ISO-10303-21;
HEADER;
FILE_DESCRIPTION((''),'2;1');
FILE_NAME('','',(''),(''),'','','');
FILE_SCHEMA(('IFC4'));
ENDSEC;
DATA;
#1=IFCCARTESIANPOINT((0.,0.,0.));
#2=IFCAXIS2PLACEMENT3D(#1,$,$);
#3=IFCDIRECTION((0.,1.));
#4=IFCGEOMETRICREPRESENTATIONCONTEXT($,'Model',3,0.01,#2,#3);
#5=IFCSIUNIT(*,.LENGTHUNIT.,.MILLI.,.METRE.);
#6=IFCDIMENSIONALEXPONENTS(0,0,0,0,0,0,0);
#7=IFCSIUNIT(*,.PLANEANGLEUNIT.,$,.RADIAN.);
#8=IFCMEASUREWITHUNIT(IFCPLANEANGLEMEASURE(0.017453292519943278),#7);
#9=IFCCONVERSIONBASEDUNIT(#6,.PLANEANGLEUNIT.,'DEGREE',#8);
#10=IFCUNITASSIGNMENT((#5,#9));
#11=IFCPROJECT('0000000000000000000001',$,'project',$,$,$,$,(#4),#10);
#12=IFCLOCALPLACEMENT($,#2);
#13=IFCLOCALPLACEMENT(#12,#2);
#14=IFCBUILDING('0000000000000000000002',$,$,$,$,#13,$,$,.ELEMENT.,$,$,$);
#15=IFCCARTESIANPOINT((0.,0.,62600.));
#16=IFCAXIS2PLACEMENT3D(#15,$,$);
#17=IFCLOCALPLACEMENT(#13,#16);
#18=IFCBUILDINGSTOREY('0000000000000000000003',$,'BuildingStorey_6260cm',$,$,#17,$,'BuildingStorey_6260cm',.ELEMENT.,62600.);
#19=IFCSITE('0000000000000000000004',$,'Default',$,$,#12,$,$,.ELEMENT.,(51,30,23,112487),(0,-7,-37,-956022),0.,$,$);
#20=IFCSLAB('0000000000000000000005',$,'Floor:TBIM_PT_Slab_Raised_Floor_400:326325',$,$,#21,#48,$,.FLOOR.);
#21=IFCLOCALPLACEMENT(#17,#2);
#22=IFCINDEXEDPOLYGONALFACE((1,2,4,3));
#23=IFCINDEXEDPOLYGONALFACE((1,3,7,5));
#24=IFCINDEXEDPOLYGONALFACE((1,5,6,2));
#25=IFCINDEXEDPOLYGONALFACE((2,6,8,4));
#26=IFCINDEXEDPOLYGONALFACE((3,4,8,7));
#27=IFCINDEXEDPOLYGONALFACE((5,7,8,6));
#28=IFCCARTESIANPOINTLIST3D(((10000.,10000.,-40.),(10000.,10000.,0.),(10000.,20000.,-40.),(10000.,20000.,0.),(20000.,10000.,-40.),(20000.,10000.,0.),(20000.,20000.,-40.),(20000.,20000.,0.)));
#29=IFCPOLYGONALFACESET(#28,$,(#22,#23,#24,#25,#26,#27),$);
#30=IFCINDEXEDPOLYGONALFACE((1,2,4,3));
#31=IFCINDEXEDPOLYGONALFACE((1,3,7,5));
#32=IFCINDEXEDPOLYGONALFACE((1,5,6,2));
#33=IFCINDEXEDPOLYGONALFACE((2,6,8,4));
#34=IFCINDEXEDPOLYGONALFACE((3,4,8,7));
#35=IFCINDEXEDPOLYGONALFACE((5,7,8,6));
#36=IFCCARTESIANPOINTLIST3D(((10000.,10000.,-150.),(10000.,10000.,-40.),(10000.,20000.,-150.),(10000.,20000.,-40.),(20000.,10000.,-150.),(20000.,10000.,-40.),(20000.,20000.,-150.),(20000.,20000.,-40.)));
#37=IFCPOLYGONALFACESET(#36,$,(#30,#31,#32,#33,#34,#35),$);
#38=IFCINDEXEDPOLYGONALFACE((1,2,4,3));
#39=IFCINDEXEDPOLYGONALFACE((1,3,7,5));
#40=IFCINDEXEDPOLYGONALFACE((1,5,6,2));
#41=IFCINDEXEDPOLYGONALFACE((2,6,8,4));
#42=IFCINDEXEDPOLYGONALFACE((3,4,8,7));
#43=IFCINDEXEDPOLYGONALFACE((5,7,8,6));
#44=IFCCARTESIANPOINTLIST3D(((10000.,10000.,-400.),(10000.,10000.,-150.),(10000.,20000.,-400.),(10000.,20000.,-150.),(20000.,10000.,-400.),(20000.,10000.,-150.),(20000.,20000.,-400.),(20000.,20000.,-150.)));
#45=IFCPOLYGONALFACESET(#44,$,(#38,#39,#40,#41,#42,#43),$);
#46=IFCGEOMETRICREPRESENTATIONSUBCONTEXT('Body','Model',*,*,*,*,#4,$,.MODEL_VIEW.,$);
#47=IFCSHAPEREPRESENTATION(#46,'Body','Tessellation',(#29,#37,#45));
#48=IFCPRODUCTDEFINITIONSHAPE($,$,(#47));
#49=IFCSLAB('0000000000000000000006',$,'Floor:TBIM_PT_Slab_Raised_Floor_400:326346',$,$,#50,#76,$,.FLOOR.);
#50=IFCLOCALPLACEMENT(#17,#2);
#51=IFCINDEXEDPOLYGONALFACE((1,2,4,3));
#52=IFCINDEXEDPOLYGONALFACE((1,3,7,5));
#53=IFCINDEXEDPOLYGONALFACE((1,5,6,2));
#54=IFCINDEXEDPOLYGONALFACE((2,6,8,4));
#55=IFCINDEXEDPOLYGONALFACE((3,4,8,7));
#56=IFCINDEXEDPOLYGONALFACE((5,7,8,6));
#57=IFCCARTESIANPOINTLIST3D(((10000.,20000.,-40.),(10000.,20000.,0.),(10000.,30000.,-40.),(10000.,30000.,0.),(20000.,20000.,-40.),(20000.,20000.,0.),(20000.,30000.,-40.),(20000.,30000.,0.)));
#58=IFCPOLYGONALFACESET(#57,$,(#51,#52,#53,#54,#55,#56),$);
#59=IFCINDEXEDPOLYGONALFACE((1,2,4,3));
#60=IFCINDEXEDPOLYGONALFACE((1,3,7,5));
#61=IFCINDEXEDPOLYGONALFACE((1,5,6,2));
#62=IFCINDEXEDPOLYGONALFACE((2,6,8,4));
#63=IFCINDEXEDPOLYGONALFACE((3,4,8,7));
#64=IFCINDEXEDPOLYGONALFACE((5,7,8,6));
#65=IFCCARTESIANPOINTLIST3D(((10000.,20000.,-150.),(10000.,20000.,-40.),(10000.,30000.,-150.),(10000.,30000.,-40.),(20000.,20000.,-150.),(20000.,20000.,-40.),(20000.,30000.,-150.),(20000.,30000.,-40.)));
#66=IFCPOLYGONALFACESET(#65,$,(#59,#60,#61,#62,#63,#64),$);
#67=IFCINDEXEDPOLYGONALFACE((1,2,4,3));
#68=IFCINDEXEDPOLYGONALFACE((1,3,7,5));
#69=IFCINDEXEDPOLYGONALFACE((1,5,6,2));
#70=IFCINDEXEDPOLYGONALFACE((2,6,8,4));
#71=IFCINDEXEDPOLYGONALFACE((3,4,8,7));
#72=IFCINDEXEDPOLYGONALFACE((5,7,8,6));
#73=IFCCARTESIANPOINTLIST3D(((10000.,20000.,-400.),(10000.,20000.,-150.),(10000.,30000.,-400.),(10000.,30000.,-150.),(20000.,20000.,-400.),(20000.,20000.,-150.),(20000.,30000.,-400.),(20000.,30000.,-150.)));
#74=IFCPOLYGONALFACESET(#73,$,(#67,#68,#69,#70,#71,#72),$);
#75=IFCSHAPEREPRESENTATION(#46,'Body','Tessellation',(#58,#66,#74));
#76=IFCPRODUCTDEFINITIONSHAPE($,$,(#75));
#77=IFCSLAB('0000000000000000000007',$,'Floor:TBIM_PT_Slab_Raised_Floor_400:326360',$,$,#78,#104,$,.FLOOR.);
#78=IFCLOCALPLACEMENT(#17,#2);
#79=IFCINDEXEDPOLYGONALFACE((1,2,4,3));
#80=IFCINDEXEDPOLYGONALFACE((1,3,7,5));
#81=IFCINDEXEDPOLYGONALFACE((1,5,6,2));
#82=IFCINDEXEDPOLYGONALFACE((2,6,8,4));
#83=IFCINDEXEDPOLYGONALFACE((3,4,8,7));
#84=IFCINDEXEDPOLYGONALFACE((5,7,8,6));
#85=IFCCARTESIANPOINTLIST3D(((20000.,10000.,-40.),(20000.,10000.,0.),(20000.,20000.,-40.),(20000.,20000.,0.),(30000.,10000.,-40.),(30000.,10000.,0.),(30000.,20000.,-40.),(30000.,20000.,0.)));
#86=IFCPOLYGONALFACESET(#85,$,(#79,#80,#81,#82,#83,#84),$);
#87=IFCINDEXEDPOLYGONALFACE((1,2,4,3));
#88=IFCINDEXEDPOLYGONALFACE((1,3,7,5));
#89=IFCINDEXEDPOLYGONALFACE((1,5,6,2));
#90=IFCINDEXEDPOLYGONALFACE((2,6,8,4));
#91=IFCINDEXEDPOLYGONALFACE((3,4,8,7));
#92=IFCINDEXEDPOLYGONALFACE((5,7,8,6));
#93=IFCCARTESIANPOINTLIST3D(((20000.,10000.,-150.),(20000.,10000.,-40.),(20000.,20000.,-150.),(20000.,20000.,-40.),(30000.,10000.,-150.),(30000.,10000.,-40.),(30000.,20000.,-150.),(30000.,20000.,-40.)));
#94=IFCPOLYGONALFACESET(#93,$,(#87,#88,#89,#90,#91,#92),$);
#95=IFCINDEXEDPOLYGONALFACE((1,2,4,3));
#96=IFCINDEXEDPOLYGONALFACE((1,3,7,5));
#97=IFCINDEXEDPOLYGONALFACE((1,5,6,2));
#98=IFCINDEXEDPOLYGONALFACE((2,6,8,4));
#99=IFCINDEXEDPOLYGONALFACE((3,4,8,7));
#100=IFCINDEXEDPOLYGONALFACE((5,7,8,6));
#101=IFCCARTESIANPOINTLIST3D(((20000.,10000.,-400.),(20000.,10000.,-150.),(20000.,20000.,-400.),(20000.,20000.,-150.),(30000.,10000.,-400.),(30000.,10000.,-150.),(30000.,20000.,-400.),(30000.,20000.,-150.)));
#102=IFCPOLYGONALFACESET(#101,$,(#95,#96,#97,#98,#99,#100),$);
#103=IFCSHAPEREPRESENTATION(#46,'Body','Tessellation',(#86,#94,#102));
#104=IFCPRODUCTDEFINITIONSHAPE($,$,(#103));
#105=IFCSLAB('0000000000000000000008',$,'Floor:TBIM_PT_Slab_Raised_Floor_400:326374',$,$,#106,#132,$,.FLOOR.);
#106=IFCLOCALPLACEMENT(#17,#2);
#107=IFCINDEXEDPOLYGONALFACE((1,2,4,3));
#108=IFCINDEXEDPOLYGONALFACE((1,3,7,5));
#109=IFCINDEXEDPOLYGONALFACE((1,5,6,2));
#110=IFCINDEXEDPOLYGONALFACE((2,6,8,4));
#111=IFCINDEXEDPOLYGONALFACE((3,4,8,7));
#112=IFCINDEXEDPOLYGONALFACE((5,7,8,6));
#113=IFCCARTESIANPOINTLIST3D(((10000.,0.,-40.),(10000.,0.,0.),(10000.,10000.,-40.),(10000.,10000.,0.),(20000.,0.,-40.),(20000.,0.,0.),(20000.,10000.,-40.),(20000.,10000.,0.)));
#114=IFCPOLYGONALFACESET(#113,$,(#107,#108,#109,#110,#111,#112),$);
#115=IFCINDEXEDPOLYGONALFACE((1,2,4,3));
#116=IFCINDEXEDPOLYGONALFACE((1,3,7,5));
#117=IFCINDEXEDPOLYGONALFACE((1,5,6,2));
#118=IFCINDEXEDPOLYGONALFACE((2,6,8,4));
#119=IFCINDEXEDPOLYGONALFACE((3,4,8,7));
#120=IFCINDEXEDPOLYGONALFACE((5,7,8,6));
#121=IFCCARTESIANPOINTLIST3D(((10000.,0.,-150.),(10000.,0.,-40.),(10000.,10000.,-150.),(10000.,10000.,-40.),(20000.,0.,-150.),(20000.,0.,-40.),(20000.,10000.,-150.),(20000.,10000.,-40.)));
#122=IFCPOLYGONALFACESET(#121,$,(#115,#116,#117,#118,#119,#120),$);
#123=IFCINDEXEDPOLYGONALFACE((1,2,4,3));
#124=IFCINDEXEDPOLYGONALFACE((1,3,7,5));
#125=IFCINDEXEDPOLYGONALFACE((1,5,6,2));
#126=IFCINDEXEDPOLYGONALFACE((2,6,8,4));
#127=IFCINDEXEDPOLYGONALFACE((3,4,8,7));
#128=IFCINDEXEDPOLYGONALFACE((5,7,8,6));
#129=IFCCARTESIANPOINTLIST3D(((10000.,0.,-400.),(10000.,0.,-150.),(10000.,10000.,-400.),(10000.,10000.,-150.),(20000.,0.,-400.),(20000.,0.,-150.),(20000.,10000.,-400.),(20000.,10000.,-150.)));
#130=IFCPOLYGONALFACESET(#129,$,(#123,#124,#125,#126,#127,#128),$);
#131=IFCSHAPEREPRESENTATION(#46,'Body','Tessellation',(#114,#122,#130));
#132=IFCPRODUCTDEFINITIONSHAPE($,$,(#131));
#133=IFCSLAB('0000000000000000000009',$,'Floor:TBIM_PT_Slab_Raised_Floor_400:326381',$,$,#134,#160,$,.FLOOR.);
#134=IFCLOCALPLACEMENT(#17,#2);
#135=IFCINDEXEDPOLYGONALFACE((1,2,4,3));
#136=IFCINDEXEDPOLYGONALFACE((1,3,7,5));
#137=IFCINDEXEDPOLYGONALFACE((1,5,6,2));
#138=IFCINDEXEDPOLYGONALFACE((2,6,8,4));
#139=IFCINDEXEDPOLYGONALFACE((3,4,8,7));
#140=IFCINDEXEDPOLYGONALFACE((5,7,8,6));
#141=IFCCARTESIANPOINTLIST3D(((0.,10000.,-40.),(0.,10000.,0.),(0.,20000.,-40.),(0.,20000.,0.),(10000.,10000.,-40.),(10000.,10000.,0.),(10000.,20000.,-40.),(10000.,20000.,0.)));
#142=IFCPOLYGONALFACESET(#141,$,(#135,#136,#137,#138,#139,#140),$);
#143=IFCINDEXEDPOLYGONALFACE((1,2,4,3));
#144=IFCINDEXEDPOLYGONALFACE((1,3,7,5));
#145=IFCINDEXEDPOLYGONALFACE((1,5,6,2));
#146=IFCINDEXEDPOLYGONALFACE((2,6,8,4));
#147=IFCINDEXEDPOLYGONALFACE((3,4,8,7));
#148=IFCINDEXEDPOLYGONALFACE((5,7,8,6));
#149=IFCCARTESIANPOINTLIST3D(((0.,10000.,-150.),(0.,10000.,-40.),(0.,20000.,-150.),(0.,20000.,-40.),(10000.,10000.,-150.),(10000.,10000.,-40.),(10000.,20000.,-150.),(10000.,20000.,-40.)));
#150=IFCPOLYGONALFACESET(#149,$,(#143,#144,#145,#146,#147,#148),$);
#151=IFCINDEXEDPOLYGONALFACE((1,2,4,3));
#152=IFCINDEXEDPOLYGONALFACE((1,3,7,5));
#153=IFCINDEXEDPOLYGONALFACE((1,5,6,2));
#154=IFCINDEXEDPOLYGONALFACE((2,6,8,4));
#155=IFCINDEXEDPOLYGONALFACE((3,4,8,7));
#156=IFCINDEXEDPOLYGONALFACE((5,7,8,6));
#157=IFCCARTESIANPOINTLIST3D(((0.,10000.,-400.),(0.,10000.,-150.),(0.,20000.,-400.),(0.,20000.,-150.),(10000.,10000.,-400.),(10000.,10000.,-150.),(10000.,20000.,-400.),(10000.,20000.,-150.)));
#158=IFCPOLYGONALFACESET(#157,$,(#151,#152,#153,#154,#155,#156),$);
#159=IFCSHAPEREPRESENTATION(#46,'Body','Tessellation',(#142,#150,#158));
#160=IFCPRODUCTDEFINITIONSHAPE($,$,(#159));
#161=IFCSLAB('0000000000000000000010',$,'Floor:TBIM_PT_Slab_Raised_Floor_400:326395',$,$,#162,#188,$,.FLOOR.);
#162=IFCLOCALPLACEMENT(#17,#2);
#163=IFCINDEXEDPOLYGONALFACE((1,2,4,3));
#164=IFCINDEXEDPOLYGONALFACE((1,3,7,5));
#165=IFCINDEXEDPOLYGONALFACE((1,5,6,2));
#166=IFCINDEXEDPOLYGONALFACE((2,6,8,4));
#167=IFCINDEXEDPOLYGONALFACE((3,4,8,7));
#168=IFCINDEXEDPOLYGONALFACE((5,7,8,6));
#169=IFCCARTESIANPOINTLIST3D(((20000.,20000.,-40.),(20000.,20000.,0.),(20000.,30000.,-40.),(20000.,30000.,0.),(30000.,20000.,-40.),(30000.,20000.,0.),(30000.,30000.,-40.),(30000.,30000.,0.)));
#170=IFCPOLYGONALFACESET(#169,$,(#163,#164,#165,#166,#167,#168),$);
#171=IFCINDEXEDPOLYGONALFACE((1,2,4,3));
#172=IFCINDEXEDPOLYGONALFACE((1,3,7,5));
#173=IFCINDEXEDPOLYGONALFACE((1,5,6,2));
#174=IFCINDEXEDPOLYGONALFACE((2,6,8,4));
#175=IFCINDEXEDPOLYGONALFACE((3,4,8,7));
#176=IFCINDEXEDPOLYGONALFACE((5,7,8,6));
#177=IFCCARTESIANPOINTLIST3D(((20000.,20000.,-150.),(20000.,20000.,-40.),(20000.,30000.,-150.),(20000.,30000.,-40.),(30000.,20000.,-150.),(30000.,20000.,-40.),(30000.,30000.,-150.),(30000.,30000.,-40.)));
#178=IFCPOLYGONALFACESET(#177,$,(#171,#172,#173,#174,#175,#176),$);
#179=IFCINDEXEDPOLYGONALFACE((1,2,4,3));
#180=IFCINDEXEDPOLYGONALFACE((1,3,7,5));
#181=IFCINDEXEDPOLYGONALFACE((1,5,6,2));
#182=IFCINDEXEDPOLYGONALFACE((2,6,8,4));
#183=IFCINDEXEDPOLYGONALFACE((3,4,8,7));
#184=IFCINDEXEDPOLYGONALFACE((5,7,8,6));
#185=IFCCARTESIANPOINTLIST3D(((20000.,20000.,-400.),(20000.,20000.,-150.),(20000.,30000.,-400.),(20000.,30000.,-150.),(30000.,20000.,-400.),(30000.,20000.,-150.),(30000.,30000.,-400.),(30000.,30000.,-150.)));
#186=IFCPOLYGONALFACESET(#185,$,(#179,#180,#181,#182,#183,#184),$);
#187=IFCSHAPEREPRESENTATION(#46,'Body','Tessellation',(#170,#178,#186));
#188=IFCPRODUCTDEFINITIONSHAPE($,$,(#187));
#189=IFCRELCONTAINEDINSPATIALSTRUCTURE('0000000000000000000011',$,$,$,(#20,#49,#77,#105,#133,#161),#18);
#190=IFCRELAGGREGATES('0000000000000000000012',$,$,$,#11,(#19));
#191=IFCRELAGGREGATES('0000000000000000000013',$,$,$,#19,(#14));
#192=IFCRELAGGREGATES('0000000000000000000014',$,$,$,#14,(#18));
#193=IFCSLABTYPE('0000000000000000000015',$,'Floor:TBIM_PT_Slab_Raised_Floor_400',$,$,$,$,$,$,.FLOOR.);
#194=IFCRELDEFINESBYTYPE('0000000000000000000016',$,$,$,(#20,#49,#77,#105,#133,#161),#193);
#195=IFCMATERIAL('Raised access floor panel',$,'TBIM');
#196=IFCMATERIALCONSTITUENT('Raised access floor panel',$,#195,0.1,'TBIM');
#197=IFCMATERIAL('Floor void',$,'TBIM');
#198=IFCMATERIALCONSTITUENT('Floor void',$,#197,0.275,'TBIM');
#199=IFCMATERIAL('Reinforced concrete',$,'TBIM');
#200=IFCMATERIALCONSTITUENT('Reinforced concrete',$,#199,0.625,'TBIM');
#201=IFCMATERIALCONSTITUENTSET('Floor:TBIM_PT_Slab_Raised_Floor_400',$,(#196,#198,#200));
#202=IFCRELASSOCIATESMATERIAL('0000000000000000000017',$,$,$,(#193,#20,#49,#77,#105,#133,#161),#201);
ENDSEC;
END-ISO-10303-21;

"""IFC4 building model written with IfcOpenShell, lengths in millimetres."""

from ifc_helpers import new_model, entity, si_unit, converted_unit, direction, frame, origin, place, context, subcontext, project, spatial, indexed_curve, outline, extrude, material, constituent, constituent_set, type_object, element, save


model = new_model("IFC4")

# Units and contexts
model_context = context("Model", 3, precision=0.01, world=origin(), true_north=direction((0.0, 1.0)))
body_context = subcontext(model_context, "Body", "Model", "MODEL_VIEW")
ifc_project = project(units=[si_unit("LENGTHUNIT", "METRE", prefix="MILLI"), converted_unit("PLANEANGLEUNIT", "DEGREE", entity("IfcPlaneAngleMeasure", 0.017453292519943278), si_unit("PLANEANGLEUNIT", "RADIAN"), dimensions=[0, 0, 0, 0, 0, 0, 0])], contexts=[model_context])

# Site, building, storey
site_placement = place(None, origin())
site = spatial("IfcSite", under=ifc_project, at=site_placement, Name="Default", CompositionType="ELEMENT", RefLatitude=(51, 30, 23, 112487), RefLongitude=(0, -7, -37, -956022), RefElevation=0.0)
building_placement = place(site_placement, origin())
building = spatial("IfcBuilding", under=site, at=building_placement, CompositionType="ELEMENT")
storey_placement = place(building_placement, frame((0.0, 0.0, 62600.0)))
storey = spatial("IfcBuildingStorey", under=building, at=storey_placement, Name="BuildingStorey_6260cm", LongName="BuildingStorey_6260cm", CompositionType="ELEMENT", Elevation=62600.0)

# Slabs
ifc_material_1 = material(Name="Raised access floor panel", Category="TBIM")
ifc_constituent_1 = constituent(ifc_material_1, Name="Raised access floor panel", Category="TBIM", fraction=0.1)
ifc_material_2 = material(Name="Floor void", Category="TBIM")
ifc_constituent_2 = constituent(ifc_material_2, Name="Floor void", Category="TBIM", fraction=0.275)
ifc_material_3 = material(Name="Reinforced concrete", Category="TBIM")
ifc_constituent_3 = constituent(ifc_material_3, Name="Reinforced concrete", Category="TBIM", fraction=0.625)
ifc_constituent_set_1 = constituent_set(constituents=[ifc_constituent_1, ifc_constituent_2, ifc_constituent_3], Name="Floor:TBIM_PT_Slab_Raised_Floor_400")
slab_type = type_object("IfcSlabType", Name="Floor:TBIM_PT_Slab_Raised_Floor_400", PredefinedType="FLOOR", material=ifc_constituent_set_1)
slab_1_placement = place(storey_placement, origin())
element("IfcSlab", 1, at=slab_1_placement, inside=storey, type_object=slab_type, material=ifc_constituent_set_1, Name="Floor:TBIM_PT_Slab_Raised_Floor_400:326325", PredefinedType="FLOOR", context=body_context, shape_type="SweptSolid", body=[
    extrude(outline(indexed_curve([(-5000.0, -5000.0), (5000.0, -5000.0), (5000.0, 5000.0), (-5000.0, 5000.0), (-5000.0, -5000.0)], self_intersect=False)), frame((15000.0, 15000.0, -40.0), z_axis=(0.0, 0.0, 1.0), x_axis=(-1.0, 0.0, 0.0)), (0.0, 0.0, 1.0), 40.0),
    extrude(outline(indexed_curve([(-5000.0, -5000.0), (5000.0, -5000.0), (5000.0, 5000.0), (-5000.0, 5000.0), (-5000.0, -5000.0)], self_intersect=False)), frame((15000.0, 15000.0, -150.0), z_axis=(0.0, 0.0, 1.0), x_axis=(-1.0, 0.0, 0.0)), (0.0, 0.0, 1.0), 110.0),
    extrude(outline(indexed_curve([(-5000.0, -5000.0), (5000.0, -5000.0), (5000.0, 5000.0), (-5000.0, 5000.0), (-5000.0, -5000.0)], self_intersect=False)), frame((15000.0, 15000.0, -400.0), z_axis=(0.0, 0.0, 1.0), x_axis=(-1.0, 0.0, 0.0)), (0.0, 0.0, 1.0), 250.0),
])
slab_2_placement = place(storey_placement, origin())
element("IfcSlab", 2, at=slab_2_placement, inside=storey, type_object=slab_type, material=ifc_constituent_set_1, Name="Floor:TBIM_PT_Slab_Raised_Floor_400:326346", PredefinedType="FLOOR", context=body_context, shape_type="SweptSolid", body=[
    extrude(outline(indexed_curve([(-5000.0, -5000.0), (5000.0, -5000.0), (5000.0, 5000.0), (-5000.0, 5000.0), (-5000.0, -5000.0)], self_intersect=False)), frame((15000.0, 25000.0, -40.0), z_axis=(0.0, 0.0, 1.0), x_axis=(-1.0, 0.0, 0.0)), (0.0, 0.0, 1.0), 40.0),
    extrude(outline(indexed_curve([(-5000.0, -5000.0), (5000.0, -5000.0), (5000.0, 5000.0), (-5000.0, 5000.0), (-5000.0, -5000.0)], self_intersect=False)), frame((15000.0, 25000.0, -150.0), z_axis=(0.0, 0.0, 1.0), x_axis=(-1.0, 0.0, 0.0)), (0.0, 0.0, 1.0), 110.0),
    extrude(outline(indexed_curve([(-5000.0, -5000.0), (5000.0, -5000.0), (5000.0, 5000.0), (-5000.0, 5000.0), (-5000.0, -5000.0)], self_intersect=False)), frame((15000.0, 25000.0, -400.0), z_axis=(0.0, 0.0, 1.0), x_axis=(-1.0, 0.0, 0.0)), (0.0, 0.0, 1.0), 250.0),
])
slab_3_placement = place(storey_placement, origin())
element("IfcSlab", 3, at=slab_3_placement, inside=storey, type_object=slab_type, material=ifc_constituent_set_1, Name="Floor:TBIM_PT_Slab_Raised_Floor_400:326360", PredefinedType="FLOOR", context=body_context, shape_type="SweptSolid", body=[
    extrude(outline(indexed_curve([(-5000.0, -5000.0), (5000.0, -5000.0), (5000.0, 5000.0), (-5000.0, 5000.0), (-5000.0, -5000.0)], self_intersect=False)), frame((25000.0, 15000.0, -40.0), z_axis=(0.0, 0.0, 1.0), x_axis=(-1.0, 0.0, 0.0)), (0.0, 0.0, 1.0), 40.0),
    extrude(outline(indexed_curve([(-5000.0, -5000.0), (5000.0, -5000.0), (5000.0, 5000.0), (-5000.0, 5000.0), (-5000.0, -5000.0)], self_intersect=False)), frame((25000.0, 15000.0, -150.0), z_axis=(0.0, 0.0, 1.0), x_axis=(-1.0, 0.0, 0.0)), (0.0, 0.0, 1.0), 110.0),
    extrude(outline(indexed_curve([(-5000.0, -5000.0), (5000.0, -5000.0), (5000.0, 5000.0), (-5000.0, 5000.0), (-5000.0, -5000.0)], self_intersect=False)), frame((25000.0, 15000.0, -400.0), z_axis=(0.0, 0.0, 1.0), x_axis=(-1.0, 0.0, 0.0)), (0.0, 0.0, 1.0), 250.0),
])
slab_4_placement = place(storey_placement, origin())
element("IfcSlab", 4, at=slab_4_placement, inside=storey, type_object=slab_type, material=ifc_constituent_set_1, Name="Floor:TBIM_PT_Slab_Raised_Floor_400:326374", PredefinedType="FLOOR", context=body_context, shape_type="SweptSolid", body=[
    extrude(outline(indexed_curve([(-5000.0, -5000.0), (5000.0, -5000.0), (5000.0, 5000.0), (-5000.0, 5000.0), (-5000.0, -5000.0)], self_intersect=False)), frame((15000.0, 5000.0, -40.0), z_axis=(0.0, 0.0, 1.0), x_axis=(0.0, 1.0, 0.0)), (0.0, 0.0, 1.0), 40.0),
    extrude(outline(indexed_curve([(-5000.0, -5000.0), (5000.0, -5000.0), (5000.0, 5000.0), (-5000.0, 5000.0), (-5000.0, -5000.0)], self_intersect=False)), frame((15000.0, 5000.0, -150.0), z_axis=(0.0, 0.0, 1.0), x_axis=(0.0, 1.0, 0.0)), (0.0, 0.0, 1.0), 110.0),
    extrude(outline(indexed_curve([(-5000.0, -5000.0), (5000.0, -5000.0), (5000.0, 5000.0), (-5000.0, 5000.0), (-5000.0, -5000.0)], self_intersect=False)), frame((15000.0, 5000.0, -400.0), z_axis=(0.0, 0.0, 1.0), x_axis=(0.0, 1.0, 0.0)), (0.0, 0.0, 1.0), 250.0),
])
slab_5_placement = place(storey_placement, origin())
element("IfcSlab", 5, at=slab_5_placement, inside=storey, type_object=slab_type, material=ifc_constituent_set_1, Name="Floor:TBIM_PT_Slab_Raised_Floor_400:326381", PredefinedType="FLOOR", context=body_context, shape_type="SweptSolid", body=[
    extrude(outline(indexed_curve([(-5000.0, -5000.0), (5000.0, -5000.0), (5000.0, 5000.0), (-5000.0, 5000.0), (-5000.0, -5000.0)], self_intersect=False)), frame((5000.0, 15000.0, -40.0), z_axis=(0.0, 0.0, 1.0), x_axis=(0.0, 1.0, 0.0)), (0.0, 0.0, 1.0), 40.0),
    extrude(outline(indexed_curve([(-5000.0, -5000.0), (5000.0, -5000.0), (5000.0, 5000.0), (-5000.0, 5000.0), (-5000.0, -5000.0)], self_intersect=False)), frame((5000.0, 15000.0, -150.0), z_axis=(0.0, 0.0, 1.0), x_axis=(0.0, 1.0, 0.0)), (0.0, 0.0, 1.0), 110.0),
    extrude(outline(indexed_curve([(-5000.0, -5000.0), (5000.0, -5000.0), (5000.0, 5000.0), (-5000.0, 5000.0), (-5000.0, -5000.0)], self_intersect=False)), frame((5000.0, 15000.0, -400.0), z_axis=(0.0, 0.0, 1.0), x_axis=(0.0, 1.0, 0.0)), (0.0, 0.0, 1.0), 250.0),
])
slab_6_placement = place(storey_placement, origin())
element("IfcSlab", 6, at=slab_6_placement, inside=storey, type_object=slab_type, material=ifc_constituent_set_1, Name="Floor:TBIM_PT_Slab_Raised_Floor_400:326395", PredefinedType="FLOOR", context=body_context, shape_type="SweptSolid", body=[
    extrude(outline(indexed_curve([(-5000.0, -5000.0), (5000.0, -5000.0), (5000.0, 5000.0), (-5000.0, 5000.0), (-5000.0, -5000.0)], self_intersect=False)), frame((25000.0, 25000.0, -40.0), z_axis=(0.0, 0.0, 1.0), x_axis=(-1.0, 0.0, 0.0)), (0.0, 0.0, 1.0), 40.0),
    extrude(outline(indexed_curve([(-5000.0, -5000.0), (5000.0, -5000.0), (5000.0, 5000.0), (-5000.0, 5000.0), (-5000.0, -5000.0)], self_intersect=False)), frame((25000.0, 25000.0, -150.0), z_axis=(0.0, 0.0, 1.0), x_axis=(-1.0, 0.0, 0.0)), (0.0, 0.0, 1.0), 110.0),
    extrude(outline(indexed_curve([(-5000.0, -5000.0), (5000.0, -5000.0), (5000.0, 5000.0), (-5000.0, 5000.0), (-5000.0, -5000.0)], self_intersect=False)), frame((25000.0, 25000.0, -400.0), z_axis=(0.0, 0.0, 1.0), x_axis=(-1.0, 0.0, 0.0)), (0.0, 0.0, 1.0), 250.0),
])

save(model, "model.ifc")
